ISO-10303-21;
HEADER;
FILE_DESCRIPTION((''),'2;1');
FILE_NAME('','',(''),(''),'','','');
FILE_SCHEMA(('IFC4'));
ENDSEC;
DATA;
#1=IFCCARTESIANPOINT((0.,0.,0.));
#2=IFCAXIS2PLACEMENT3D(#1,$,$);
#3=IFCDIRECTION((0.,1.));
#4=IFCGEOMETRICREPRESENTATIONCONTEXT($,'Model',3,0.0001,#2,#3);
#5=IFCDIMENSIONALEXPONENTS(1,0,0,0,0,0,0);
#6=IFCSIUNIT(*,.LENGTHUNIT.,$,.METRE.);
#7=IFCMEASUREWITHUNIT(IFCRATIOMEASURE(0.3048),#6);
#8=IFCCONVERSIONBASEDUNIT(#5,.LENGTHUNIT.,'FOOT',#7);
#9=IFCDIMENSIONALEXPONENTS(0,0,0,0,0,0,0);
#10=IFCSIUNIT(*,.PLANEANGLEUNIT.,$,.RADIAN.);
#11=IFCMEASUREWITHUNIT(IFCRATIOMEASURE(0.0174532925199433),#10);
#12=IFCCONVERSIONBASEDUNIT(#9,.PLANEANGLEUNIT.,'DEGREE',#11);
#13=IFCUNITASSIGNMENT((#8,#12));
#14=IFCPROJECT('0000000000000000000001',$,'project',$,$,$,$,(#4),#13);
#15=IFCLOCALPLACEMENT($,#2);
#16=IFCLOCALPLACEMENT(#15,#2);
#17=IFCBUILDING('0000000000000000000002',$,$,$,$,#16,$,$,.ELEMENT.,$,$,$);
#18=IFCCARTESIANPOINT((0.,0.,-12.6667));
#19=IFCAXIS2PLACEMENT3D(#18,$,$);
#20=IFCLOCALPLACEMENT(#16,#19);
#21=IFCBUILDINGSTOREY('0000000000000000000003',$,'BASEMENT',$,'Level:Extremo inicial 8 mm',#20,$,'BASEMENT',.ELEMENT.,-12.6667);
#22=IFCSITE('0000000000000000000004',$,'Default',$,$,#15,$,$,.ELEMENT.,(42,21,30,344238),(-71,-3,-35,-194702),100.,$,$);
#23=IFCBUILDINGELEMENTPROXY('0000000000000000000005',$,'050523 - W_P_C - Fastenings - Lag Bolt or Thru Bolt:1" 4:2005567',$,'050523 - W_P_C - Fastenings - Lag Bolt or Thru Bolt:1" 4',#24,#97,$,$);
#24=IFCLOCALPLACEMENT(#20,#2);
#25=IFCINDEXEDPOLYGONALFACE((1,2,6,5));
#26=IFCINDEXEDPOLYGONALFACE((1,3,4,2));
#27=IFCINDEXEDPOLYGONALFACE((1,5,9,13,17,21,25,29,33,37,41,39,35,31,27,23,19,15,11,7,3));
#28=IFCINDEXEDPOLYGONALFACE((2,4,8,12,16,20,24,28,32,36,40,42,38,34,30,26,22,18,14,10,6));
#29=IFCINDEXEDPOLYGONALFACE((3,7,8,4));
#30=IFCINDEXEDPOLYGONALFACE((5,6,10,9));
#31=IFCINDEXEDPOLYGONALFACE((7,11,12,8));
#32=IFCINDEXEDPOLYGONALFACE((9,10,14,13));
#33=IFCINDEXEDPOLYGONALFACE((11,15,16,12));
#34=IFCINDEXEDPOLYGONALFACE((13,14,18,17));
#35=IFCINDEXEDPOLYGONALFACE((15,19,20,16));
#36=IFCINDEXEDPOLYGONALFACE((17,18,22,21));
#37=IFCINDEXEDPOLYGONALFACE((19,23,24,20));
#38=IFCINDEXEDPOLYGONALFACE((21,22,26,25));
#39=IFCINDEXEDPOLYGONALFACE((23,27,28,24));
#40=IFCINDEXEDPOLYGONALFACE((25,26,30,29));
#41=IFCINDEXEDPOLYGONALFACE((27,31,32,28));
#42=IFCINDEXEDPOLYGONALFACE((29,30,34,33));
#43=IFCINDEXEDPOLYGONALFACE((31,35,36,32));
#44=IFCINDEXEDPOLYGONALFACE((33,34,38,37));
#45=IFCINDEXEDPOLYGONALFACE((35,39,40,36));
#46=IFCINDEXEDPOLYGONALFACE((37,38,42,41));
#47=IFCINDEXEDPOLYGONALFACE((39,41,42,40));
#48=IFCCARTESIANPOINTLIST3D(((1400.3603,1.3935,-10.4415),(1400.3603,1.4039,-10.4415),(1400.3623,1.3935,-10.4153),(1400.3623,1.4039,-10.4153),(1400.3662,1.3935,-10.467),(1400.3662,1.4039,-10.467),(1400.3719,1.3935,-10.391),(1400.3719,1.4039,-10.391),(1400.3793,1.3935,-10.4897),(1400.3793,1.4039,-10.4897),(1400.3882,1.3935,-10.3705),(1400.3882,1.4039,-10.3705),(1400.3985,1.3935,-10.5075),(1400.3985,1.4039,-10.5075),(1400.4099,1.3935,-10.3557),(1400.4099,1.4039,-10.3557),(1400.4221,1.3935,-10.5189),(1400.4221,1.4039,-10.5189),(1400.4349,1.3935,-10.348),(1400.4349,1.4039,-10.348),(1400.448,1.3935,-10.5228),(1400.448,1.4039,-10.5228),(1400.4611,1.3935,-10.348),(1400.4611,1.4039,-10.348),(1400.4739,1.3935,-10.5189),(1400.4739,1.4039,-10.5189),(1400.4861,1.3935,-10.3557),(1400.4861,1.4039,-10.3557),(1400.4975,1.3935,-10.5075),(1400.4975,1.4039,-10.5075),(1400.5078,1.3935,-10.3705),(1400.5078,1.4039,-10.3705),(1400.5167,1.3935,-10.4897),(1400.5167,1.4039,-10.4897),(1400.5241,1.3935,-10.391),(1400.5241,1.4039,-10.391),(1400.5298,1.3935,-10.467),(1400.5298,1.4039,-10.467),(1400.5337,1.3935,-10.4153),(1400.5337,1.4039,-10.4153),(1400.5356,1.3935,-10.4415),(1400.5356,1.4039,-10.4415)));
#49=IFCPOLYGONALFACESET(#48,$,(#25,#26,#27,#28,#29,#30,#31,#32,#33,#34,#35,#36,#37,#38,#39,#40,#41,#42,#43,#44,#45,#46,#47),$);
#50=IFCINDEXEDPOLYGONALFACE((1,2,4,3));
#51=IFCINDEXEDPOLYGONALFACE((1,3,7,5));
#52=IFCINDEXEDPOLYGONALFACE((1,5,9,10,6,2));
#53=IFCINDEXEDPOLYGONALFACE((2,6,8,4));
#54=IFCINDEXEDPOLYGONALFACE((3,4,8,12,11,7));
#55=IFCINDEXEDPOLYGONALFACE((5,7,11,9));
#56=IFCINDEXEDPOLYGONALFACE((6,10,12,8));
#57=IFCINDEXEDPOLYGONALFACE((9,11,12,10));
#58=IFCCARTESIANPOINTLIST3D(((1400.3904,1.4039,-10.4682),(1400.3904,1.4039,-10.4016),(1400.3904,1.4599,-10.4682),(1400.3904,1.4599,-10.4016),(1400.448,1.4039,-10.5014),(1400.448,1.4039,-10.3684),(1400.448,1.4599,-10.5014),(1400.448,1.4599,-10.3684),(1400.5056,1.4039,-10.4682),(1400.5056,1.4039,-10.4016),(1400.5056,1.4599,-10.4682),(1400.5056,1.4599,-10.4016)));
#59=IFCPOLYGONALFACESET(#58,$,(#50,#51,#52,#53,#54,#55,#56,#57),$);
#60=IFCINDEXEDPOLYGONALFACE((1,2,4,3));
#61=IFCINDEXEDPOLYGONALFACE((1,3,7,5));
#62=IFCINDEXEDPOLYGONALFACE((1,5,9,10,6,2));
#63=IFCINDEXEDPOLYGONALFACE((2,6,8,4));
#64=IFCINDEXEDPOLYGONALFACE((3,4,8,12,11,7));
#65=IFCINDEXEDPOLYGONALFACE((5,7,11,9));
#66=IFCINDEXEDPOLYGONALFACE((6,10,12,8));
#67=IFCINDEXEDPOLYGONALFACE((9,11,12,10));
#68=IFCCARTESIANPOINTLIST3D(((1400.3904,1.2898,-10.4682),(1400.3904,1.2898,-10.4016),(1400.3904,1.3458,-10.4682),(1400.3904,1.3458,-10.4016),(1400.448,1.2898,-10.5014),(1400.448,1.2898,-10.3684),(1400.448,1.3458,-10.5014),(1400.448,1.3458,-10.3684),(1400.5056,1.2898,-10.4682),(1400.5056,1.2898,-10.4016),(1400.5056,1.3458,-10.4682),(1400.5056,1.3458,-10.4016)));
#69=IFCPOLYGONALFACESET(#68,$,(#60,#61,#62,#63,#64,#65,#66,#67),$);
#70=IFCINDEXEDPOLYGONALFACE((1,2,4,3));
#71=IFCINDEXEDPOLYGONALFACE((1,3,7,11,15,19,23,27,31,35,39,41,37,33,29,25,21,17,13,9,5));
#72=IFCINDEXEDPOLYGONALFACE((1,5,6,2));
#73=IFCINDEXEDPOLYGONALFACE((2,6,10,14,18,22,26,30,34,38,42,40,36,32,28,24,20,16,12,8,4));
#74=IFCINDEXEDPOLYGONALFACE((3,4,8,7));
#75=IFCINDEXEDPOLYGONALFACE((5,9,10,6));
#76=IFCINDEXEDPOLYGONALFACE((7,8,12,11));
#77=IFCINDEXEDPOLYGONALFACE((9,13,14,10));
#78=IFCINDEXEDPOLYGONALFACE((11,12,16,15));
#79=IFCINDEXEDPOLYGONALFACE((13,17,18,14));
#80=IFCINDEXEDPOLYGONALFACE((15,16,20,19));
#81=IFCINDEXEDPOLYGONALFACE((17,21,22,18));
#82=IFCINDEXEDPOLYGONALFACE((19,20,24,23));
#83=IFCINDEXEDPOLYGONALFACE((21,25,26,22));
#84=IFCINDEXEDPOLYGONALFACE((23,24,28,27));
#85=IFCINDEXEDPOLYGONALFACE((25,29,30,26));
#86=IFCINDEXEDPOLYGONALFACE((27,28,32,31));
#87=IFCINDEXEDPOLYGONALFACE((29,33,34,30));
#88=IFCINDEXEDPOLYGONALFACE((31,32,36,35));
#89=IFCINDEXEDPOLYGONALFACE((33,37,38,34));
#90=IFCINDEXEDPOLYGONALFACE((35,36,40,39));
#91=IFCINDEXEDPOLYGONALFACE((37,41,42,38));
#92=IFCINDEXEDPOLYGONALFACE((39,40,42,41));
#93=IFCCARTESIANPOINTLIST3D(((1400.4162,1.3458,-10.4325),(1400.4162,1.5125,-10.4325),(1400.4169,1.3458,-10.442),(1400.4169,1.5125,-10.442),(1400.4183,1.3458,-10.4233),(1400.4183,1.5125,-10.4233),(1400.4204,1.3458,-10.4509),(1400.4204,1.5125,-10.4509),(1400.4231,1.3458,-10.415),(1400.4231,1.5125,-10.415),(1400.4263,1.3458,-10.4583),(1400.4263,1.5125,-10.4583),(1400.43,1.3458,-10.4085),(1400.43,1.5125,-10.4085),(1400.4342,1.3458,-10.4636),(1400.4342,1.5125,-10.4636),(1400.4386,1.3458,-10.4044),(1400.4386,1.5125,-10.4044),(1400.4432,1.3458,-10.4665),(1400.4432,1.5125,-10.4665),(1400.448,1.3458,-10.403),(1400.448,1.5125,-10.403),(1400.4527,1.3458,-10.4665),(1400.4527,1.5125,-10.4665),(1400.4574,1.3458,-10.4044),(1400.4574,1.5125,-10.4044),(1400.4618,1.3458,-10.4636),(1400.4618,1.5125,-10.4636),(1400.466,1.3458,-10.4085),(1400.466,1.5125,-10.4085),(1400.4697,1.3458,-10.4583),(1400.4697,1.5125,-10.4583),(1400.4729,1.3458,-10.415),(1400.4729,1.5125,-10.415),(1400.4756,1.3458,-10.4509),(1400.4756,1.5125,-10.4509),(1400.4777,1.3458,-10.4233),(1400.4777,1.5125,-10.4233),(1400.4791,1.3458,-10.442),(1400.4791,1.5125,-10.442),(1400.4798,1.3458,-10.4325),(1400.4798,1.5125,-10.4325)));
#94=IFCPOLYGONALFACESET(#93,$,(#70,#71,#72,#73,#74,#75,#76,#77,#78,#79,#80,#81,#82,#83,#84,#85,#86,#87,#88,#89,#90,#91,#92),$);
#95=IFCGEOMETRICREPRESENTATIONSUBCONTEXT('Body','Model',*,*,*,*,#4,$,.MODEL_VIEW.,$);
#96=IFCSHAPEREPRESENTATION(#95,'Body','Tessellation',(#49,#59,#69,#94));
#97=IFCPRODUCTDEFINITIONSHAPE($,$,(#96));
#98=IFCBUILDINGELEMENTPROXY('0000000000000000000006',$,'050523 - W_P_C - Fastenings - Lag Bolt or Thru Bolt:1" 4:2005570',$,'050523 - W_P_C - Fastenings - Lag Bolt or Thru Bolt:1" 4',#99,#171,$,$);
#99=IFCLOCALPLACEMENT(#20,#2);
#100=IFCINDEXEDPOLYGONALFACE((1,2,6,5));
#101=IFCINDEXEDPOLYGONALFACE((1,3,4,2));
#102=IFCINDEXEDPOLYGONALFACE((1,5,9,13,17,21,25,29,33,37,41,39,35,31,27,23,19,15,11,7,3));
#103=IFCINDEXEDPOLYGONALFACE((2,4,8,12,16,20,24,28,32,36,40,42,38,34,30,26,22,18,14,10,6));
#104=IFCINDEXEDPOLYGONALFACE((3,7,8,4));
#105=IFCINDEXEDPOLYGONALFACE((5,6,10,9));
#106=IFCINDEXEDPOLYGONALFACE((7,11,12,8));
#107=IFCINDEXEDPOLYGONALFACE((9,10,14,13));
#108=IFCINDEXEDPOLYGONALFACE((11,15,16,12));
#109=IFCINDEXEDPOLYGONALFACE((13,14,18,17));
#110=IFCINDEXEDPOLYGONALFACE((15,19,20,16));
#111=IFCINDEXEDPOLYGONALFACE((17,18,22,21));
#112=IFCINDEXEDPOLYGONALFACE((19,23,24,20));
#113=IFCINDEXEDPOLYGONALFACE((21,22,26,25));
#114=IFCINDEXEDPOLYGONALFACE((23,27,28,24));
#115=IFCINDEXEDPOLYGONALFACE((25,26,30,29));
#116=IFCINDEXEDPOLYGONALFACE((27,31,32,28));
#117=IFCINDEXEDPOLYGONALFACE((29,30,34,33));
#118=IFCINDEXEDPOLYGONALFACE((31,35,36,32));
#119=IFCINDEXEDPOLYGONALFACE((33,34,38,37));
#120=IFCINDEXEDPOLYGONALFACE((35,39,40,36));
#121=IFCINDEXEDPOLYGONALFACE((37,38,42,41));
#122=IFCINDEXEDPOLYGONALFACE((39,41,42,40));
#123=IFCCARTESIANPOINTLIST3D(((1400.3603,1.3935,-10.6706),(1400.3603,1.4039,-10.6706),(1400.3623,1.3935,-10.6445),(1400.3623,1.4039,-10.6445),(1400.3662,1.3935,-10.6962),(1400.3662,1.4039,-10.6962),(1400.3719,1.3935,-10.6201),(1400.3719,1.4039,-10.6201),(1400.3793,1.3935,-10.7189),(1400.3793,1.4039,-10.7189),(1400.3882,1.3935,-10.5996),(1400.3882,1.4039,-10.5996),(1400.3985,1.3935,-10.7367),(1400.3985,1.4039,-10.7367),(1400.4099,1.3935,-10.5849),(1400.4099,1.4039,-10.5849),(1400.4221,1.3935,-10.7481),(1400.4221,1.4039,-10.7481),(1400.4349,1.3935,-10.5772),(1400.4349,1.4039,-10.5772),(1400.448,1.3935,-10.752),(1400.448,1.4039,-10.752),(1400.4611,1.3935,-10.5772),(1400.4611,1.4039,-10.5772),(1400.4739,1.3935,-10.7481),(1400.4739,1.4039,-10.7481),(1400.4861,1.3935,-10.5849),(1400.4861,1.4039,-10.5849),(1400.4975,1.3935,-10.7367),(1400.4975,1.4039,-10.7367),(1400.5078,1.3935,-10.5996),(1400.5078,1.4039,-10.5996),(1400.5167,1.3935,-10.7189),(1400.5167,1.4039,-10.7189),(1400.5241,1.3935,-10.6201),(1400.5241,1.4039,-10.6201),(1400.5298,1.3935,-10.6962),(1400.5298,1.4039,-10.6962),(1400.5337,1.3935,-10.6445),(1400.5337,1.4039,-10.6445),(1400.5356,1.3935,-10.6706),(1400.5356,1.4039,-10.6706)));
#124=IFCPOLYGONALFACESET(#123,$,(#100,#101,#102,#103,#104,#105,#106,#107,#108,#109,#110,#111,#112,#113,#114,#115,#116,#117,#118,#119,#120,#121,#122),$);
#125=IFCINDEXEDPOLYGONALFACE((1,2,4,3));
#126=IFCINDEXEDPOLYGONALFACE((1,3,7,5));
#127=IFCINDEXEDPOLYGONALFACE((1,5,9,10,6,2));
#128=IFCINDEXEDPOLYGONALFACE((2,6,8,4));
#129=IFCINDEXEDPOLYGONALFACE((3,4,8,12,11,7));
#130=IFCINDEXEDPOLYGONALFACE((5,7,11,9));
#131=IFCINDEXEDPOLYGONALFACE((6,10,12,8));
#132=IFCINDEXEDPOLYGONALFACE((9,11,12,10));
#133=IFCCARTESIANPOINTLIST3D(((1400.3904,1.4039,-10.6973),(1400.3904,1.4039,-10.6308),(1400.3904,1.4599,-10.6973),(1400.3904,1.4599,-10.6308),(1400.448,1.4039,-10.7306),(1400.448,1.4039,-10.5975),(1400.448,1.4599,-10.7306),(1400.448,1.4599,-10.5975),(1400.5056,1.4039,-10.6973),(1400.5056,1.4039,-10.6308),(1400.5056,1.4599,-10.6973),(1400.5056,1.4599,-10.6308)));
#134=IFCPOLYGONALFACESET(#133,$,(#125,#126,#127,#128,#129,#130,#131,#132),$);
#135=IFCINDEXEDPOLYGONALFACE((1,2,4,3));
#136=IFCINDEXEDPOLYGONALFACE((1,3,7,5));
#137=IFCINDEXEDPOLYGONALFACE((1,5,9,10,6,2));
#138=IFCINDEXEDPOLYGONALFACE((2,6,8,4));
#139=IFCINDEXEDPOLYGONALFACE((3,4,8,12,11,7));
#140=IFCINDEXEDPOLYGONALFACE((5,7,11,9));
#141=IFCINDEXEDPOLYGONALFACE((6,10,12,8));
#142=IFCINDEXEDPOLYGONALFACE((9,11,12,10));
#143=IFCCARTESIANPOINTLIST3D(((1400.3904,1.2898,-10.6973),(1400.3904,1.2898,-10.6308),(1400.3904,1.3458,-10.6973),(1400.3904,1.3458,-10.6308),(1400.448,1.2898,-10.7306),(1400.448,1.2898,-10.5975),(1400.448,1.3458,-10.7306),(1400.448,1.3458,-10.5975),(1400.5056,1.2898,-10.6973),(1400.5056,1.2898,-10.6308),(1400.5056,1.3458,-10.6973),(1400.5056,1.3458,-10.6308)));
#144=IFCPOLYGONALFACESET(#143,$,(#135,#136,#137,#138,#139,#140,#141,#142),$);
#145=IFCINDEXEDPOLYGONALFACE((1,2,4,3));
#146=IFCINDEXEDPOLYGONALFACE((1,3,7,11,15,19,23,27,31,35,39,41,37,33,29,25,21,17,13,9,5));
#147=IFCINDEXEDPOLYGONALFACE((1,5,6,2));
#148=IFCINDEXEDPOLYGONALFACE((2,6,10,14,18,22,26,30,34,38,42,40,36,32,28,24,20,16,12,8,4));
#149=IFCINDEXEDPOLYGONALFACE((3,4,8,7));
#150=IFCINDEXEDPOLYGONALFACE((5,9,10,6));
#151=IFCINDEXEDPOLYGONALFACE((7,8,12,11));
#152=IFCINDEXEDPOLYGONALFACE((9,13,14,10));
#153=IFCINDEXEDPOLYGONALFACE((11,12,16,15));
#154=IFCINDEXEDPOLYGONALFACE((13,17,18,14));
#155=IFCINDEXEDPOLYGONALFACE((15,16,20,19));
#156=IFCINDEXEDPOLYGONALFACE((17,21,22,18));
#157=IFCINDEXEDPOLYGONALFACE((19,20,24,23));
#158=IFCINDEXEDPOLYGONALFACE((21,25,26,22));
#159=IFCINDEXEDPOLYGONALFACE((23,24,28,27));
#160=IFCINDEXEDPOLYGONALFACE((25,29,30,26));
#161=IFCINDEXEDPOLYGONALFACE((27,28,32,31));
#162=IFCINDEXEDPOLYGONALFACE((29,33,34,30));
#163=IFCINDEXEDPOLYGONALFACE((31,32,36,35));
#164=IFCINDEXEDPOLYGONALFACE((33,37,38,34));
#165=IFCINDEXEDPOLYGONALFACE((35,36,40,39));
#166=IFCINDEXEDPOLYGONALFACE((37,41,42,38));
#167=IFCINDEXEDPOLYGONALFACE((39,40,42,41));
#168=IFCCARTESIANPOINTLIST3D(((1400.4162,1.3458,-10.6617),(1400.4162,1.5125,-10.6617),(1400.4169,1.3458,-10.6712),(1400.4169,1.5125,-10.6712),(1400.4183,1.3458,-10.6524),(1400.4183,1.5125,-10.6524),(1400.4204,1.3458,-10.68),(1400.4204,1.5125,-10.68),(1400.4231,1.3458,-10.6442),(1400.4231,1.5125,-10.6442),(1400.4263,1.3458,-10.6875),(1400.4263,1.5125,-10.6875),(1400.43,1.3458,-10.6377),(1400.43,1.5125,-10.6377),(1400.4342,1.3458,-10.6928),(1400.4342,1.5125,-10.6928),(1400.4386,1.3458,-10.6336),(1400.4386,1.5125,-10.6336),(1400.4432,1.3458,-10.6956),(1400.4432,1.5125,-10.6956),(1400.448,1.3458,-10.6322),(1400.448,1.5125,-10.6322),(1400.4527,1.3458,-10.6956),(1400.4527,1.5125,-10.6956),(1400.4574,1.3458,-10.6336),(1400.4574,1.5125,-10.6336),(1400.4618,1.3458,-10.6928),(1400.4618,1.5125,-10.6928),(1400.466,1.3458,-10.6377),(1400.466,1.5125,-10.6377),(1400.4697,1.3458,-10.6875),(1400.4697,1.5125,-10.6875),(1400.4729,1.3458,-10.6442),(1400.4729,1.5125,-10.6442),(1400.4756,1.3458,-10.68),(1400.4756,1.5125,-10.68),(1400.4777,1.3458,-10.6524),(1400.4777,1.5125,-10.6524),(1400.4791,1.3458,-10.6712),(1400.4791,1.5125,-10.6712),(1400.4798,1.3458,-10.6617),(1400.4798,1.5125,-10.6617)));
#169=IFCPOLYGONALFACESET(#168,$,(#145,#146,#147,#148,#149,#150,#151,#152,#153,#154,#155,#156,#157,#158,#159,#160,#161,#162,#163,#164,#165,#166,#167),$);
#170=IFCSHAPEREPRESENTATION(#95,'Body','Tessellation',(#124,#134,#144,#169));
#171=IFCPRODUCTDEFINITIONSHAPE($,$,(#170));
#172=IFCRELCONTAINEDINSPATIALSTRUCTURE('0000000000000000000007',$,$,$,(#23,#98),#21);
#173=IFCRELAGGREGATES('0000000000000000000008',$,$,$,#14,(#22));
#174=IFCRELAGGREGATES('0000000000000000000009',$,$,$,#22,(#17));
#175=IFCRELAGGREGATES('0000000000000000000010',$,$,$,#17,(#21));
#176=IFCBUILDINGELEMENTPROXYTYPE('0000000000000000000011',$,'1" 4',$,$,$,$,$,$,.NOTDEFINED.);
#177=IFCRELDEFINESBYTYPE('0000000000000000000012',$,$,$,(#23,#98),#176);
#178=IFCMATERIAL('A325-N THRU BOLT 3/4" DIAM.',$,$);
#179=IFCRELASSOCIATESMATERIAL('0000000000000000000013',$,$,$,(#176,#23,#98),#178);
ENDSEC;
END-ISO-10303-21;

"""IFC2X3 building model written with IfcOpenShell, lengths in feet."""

from ifc_helpers import new_model, entity, si_unit, converted_unit, direction, frame, frame_2d, origin, place, context, subcontext, project, spatial, polyline, circle, outline, extrude, source, transform, mapped, material, type_object, type_shapes, element, save


model = new_model("IFC2X3")

# Units and contexts
model_context = context("Model", 3, precision=0.0001, world=origin(), true_north=direction((0.0, 1.0)))
body_context = subcontext(model_context, "Body", "Model", "MODEL_VIEW")
ifc_project = project(units=[converted_unit("LENGTHUNIT", "FOOT", entity("IfcRatioMeasure", 0.3048), si_unit("LENGTHUNIT", "METRE"), dimensions=[1, 0, 0, 0, 0, 0, 0]), converted_unit("PLANEANGLEUNIT", "DEGREE", entity("IfcRatioMeasure", 0.0174532925199433), si_unit("PLANEANGLEUNIT", "RADIAN"), dimensions=[0, 0, 0, 0, 0, 0, 0])], contexts=[model_context])

# Site, building, storey
site_placement = place(None, origin())
site = spatial("IfcSite", under=ifc_project, at=site_placement, Name="Default", CompositionType="ELEMENT", RefLatitude=(42, 21, 30, 344238), RefLongitude=(-71, -3, -35, -194702), RefElevation=100.0)
building_placement = place(site_placement, origin())
building = spatial("IfcBuilding", under=site, at=building_placement, CompositionType="ELEMENT")
storey_placement = place(building_placement, frame((0.0, 0.0, -12.6667)))
storey = spatial("IfcBuildingStorey", under=building, at=storey_placement, Name="BASEMENT", ObjectType="Level:Extremo inicial 8 mm", LongName="BASEMENT", CompositionType="ELEMENT", Elevation=-12.6667)

# Building element proxies
ifc_material_1 = material(Name="A325-N THRU BOLT 3/4\" DIAM.")
building_element_proxy_type_1 = type_object("IfcBuildingElementProxyType", Name="1\" 4", PredefinedType="NOTDEFINED", material=ifc_material_1)
shared_shape_1 = source(origin(), body_context, "Body", "SweptSolid", [
    extrude(circle(Radius=0.0879, at=frame_2d((0.0, 0.0), x_axis=(1.0, 0.0))), frame((0.0, 0.0, -0.0581), z_axis=(0.0, 0.0, 1.0), x_axis=(0.0, -1.0, 0.0)), (0.0, 0.0, 1.0), 0.0104),
    extrude(outline(polyline([(-0.0333, -0.0576), (0.0333, -0.0576), (0.0665, 0.0), (0.0333, 0.0576), (-0.0333, 0.0576), (-0.0665, 0.0), (-0.0333, -0.0576)])), frame((0.0, 0.0, -0.1141), z_axis=(0.0, 0.0, 1.0), x_axis=(0.866025, -0.5, 0.0)), (0.0, 0.0, 1.0), 0.056),
    extrude(outline(polyline([(-0.0333, -0.0576), (0.0333, -0.0576), (0.0665, 0.0), (0.0333, 0.0576), (-0.0333, 0.0576), (-0.0665, 0.0), (-0.0333, -0.0576)])), frame((0.0, 0.0, 0.0), z_axis=(0.0, 0.0, 1.0), x_axis=(0.0, -1.0, 0.0)), (0.0, 0.0, 1.0), 0.056),
    extrude(circle(Radius=0.0319, at=frame_2d((0.0, 0.0), x_axis=(1.0, 0.0))), frame((0.0, 0.0, -0.1667), z_axis=(0.0, 0.0, 1.0), x_axis=(0.0, 1.0, 0.0)), (0.0, 0.0, 1.0), 0.1667),
])
type_shapes(building_element_proxy_type_1, [shared_shape_1])
for number, where, z_axis, x_axis, name in (
    (1, (1400.448, 1.3458, -10.4349), (0.0, -1.0, 0.0), (1.0, 0.0, 0.0), "050523 - W_P_C - Fastenings - Lag Bolt or Thru Bolt:1\" 4:2005567"),
    (2, (1400.448, 1.3458, -10.6641), (0.0, -1.0, 0.0), (1.0, 0.0, 0.0), "050523 - W_P_C - Fastenings - Lag Bolt or Thru Bolt:1\" 4:2005570"),
):
    element("IfcBuildingElementProxy", number, at=place(storey_placement, frame(where, z_axis=z_axis, x_axis=x_axis)), inside=storey, type_object=building_element_proxy_type_1, material=ifc_material_1, Name=name, ObjectType="050523 - W_P_C - Fastenings - Lag Bolt or Thru Bolt:1\" 4", context=body_context, shape_type="MappedRepresentation", body=[
        mapped(shared_shape_1, transform((0.0, 0.0, 0.0), scale=1.0)),
    ])

save(model, "model.ifc")
